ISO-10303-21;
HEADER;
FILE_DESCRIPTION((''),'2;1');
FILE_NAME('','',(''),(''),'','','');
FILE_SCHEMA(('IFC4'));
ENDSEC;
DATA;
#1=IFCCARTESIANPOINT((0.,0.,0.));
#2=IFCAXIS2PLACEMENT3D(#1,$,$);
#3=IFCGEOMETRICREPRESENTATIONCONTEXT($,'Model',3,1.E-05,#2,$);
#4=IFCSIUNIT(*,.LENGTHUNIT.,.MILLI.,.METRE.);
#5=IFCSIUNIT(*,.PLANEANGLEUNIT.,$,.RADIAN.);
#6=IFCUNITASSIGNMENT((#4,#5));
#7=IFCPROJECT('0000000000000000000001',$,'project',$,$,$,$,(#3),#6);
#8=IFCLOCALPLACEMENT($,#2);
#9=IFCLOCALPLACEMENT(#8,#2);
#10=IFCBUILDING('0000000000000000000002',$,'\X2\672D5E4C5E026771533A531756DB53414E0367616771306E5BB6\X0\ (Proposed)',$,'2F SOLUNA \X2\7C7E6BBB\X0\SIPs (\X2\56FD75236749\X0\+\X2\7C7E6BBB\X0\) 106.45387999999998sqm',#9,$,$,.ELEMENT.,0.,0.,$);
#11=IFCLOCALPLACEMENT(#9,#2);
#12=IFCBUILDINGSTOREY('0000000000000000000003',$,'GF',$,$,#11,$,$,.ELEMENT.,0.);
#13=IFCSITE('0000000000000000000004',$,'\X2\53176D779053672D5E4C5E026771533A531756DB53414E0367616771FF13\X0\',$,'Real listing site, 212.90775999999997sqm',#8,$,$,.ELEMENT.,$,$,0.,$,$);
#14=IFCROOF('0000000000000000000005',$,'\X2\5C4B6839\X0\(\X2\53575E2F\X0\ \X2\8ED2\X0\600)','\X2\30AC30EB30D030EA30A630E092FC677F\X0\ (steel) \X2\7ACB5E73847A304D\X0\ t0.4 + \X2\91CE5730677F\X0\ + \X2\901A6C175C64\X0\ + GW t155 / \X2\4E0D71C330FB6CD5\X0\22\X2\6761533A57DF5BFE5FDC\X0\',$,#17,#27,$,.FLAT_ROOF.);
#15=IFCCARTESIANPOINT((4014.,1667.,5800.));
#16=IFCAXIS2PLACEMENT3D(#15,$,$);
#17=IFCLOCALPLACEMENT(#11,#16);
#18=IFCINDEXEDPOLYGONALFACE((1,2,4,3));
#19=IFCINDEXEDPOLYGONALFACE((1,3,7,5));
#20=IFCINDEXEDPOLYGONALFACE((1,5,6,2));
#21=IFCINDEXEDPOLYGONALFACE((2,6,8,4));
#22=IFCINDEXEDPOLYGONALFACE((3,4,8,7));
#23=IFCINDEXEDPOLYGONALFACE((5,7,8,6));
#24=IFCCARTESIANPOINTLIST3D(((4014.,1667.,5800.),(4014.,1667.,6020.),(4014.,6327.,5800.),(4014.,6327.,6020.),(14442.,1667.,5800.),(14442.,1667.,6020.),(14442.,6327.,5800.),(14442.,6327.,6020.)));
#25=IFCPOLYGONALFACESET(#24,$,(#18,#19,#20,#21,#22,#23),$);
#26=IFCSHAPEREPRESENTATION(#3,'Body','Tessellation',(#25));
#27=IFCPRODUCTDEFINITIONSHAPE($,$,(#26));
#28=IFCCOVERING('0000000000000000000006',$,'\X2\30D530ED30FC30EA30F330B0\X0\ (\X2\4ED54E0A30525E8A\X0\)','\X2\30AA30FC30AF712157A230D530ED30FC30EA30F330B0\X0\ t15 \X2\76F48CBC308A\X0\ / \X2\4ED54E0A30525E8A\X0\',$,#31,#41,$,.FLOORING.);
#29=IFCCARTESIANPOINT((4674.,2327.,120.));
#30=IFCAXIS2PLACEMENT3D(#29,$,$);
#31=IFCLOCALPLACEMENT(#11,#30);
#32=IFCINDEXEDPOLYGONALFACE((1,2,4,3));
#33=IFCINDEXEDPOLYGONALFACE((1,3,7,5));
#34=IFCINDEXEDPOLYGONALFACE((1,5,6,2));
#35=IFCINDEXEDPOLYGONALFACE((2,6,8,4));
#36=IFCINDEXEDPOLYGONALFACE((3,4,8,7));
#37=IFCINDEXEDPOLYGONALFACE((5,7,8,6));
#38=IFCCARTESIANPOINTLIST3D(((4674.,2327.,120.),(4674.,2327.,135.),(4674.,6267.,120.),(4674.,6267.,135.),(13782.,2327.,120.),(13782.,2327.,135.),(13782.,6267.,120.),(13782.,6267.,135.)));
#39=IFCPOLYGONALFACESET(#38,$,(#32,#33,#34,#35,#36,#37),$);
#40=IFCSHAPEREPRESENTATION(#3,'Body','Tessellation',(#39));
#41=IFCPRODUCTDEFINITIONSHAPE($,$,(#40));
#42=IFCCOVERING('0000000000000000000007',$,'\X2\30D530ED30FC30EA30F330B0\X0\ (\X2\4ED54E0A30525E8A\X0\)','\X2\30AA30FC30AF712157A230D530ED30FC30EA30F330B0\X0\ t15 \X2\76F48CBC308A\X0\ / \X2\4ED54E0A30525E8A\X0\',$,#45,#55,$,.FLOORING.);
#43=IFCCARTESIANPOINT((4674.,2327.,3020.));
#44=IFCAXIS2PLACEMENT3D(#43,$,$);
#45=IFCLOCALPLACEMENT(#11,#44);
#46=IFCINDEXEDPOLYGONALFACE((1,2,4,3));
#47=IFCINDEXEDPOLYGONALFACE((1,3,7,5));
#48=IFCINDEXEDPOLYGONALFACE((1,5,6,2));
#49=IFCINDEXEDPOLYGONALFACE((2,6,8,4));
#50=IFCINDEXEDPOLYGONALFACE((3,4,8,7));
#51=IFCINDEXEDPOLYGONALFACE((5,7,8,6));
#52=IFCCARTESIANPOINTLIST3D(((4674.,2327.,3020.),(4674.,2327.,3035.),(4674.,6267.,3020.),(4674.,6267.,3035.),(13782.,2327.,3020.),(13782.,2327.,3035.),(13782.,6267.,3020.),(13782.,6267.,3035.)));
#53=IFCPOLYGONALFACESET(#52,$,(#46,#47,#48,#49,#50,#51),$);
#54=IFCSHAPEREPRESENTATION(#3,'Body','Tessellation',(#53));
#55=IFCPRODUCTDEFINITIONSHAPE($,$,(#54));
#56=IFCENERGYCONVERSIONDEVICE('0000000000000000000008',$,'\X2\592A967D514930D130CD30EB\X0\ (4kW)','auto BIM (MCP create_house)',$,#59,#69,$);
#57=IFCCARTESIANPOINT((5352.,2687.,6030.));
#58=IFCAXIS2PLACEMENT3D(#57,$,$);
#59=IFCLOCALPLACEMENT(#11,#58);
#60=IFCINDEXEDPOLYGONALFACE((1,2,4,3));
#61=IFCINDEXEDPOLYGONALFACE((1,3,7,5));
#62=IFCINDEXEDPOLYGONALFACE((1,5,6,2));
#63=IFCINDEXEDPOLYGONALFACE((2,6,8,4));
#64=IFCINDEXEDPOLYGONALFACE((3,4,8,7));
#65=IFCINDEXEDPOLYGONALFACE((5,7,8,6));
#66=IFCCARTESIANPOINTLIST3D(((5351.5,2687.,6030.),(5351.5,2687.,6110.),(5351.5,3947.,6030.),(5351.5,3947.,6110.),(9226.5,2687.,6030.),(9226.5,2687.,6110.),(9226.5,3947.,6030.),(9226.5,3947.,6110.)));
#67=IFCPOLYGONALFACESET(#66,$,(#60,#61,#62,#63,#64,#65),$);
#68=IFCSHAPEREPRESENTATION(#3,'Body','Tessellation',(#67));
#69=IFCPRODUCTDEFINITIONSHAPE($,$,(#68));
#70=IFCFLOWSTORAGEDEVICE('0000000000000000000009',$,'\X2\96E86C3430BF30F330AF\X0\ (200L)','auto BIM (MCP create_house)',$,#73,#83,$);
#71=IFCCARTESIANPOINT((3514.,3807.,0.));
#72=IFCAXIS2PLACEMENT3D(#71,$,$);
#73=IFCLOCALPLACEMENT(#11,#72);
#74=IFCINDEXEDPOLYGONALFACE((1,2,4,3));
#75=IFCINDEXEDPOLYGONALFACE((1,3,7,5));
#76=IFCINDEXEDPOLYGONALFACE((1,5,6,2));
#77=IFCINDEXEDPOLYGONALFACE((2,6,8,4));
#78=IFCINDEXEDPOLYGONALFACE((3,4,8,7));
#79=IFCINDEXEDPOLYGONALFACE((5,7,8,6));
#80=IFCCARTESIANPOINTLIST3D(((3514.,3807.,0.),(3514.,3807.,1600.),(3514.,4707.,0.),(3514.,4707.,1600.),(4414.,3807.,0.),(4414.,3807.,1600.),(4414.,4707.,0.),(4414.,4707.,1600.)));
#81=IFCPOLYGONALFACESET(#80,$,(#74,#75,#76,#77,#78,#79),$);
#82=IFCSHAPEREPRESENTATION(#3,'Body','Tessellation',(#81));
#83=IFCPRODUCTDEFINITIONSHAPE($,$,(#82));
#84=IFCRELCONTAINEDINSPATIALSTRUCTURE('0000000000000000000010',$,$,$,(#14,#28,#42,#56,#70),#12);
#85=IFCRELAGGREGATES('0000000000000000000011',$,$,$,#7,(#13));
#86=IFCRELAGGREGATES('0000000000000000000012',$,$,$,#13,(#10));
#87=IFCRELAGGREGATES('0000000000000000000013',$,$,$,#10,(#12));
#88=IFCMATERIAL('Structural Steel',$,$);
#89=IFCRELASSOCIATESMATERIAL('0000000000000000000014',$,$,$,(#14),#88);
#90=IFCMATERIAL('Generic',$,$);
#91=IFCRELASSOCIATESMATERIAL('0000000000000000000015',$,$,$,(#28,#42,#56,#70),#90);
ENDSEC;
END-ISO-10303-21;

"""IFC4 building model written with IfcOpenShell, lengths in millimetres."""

from ifc_helpers import new_model, si_unit, frame, frame_2d, origin, place, context, project, spatial, rectangle, extrude, material, element, save


model = new_model("IFC4")

# Units and contexts
model_context = context("Model", 3, precision=1e-05, world=origin())
ifc_project = project(units=[si_unit("LENGTHUNIT", "METRE", prefix="MILLI"), si_unit("PLANEANGLEUNIT", "RADIAN")], contexts=[model_context])

# Site, building, storey
site_placement = place(None, origin())
site = spatial("IfcSite", under=ifc_project, at=site_placement, Name="北海道札幌市東区北四十七条東３", ObjectType="Real listing site, 212.90775999999997sqm", CompositionType="ELEMENT", RefElevation=0.0)
building_placement = place(site_placement, origin())
building = spatial("IfcBuilding", under=site, at=building_placement, Name="札幌市東区北四十七条東の家 (Proposed)", ObjectType="2F SOLUNA 籾殻SIPs (国産杉+籾殻) 106.45387999999998sqm", CompositionType="ELEMENT", ElevationOfRefHeight=0.0, ElevationOfTerrain=0.0)
storey_placement = place(building_placement, origin())
storey = spatial("IfcBuildingStorey", under=building, at=storey_placement, Name="GF", CompositionType="ELEMENT", Elevation=0.0)

# Roof
ifc_material_1 = material(Name="Structural Steel")
for number, where, name in (
    (1, (4014.0, 1667.0, 5800.0), "屋根(南帯 軒600)"),
):
    element("IfcRoof", number, at=place(storey_placement, frame(where)), inside=storey, material=ifc_material_1, Name=name, Description="ガルバリウム鋼板 (steel) 立平葺き t0.4 + 野地板 + 通気層 + GW t155 / 不燃・法22条区域対応", PredefinedType="FLAT_ROOF", context=model_context, shape_type="SweptSolid", body=[
        extrude(rectangle(XDim=10428.0, YDim=4660.0, at=frame_2d((5214.0, 2330.0))), frame((4014.0, 1667.0, 5800.0)), (0.0, 0.0, 1.0), 220.0),
    ])

# Coverings
ifc_material_2 = material(Name="Generic")
covering_1_placement = place(storey_placement, frame((4674.0, 2327.0, 120.0)))
element("IfcCovering", 2, at=covering_1_placement, inside=storey, material=ifc_material_2, Name="フローリング (仕上げ床)", Description="オーク無垢フローリング t15 直貼り / 仕上げ床", PredefinedType="FLOORING", context=model_context, shape_type="SweptSolid", body=[
    extrude(rectangle(XDim=9108.0, YDim=3940.0, at=frame_2d((4554.0, 1970.0))), frame((4674.0, 2327.0, 120.0)), (0.0, 0.0, 1.0), 15.0),
])
covering_2_placement = place(storey_placement, frame((4674.0, 2327.0, 3020.0)))
element("IfcCovering", 3, at=covering_2_placement, inside=storey, material=ifc_material_2, Name="フローリング (仕上げ床)", Description="オーク無垢フローリング t15 直貼り / 仕上げ床", PredefinedType="FLOORING", context=model_context, shape_type="SweptSolid", body=[
    extrude(rectangle(XDim=9108.0, YDim=3940.0, at=frame_2d((4554.0, 1970.0))), frame((4674.0, 2327.0, 3020.0)), (0.0, 0.0, 1.0), 15.0),
])

# Energy conversion device
energy_conversion_device_placement = place(storey_placement, frame((5352.0, 2687.0, 6030.0)))
element("IfcEnergyConversionDevice", 4, at=energy_conversion_device_placement, inside=storey, material=ifc_material_2, Name="太陽光パネル (4kW)", Description="auto BIM (MCP create_house)", context=model_context, shape_type="SweptSolid", body=[
    extrude(rectangle(XDim=3875.0, YDim=1260.0, at=frame_2d((1937.0, 630.0))), frame((5352.0, 2687.0, 6030.0)), (0.0, 0.0, 1.0), 80.0),
])

# Flow storage device
flow_storage_device_placement = place(storey_placement, frame((3514.0, 3807.0, 0.0)))
element("IfcFlowStorageDevice", 5, at=flow_storage_device_placement, inside=storey, material=ifc_material_2, Name="雨水タンク (200L)", Description="auto BIM (MCP create_house)", context=model_context, shape_type="SweptSolid", body=[
    extrude(rectangle(XDim=900.0, YDim=900.0, at=frame_2d((450.0, 450.0))), frame((3514.0, 3807.0, 0.0)), (0.0, 0.0, 1.0), 1600.0),
])

save(model, "model.ifc")
